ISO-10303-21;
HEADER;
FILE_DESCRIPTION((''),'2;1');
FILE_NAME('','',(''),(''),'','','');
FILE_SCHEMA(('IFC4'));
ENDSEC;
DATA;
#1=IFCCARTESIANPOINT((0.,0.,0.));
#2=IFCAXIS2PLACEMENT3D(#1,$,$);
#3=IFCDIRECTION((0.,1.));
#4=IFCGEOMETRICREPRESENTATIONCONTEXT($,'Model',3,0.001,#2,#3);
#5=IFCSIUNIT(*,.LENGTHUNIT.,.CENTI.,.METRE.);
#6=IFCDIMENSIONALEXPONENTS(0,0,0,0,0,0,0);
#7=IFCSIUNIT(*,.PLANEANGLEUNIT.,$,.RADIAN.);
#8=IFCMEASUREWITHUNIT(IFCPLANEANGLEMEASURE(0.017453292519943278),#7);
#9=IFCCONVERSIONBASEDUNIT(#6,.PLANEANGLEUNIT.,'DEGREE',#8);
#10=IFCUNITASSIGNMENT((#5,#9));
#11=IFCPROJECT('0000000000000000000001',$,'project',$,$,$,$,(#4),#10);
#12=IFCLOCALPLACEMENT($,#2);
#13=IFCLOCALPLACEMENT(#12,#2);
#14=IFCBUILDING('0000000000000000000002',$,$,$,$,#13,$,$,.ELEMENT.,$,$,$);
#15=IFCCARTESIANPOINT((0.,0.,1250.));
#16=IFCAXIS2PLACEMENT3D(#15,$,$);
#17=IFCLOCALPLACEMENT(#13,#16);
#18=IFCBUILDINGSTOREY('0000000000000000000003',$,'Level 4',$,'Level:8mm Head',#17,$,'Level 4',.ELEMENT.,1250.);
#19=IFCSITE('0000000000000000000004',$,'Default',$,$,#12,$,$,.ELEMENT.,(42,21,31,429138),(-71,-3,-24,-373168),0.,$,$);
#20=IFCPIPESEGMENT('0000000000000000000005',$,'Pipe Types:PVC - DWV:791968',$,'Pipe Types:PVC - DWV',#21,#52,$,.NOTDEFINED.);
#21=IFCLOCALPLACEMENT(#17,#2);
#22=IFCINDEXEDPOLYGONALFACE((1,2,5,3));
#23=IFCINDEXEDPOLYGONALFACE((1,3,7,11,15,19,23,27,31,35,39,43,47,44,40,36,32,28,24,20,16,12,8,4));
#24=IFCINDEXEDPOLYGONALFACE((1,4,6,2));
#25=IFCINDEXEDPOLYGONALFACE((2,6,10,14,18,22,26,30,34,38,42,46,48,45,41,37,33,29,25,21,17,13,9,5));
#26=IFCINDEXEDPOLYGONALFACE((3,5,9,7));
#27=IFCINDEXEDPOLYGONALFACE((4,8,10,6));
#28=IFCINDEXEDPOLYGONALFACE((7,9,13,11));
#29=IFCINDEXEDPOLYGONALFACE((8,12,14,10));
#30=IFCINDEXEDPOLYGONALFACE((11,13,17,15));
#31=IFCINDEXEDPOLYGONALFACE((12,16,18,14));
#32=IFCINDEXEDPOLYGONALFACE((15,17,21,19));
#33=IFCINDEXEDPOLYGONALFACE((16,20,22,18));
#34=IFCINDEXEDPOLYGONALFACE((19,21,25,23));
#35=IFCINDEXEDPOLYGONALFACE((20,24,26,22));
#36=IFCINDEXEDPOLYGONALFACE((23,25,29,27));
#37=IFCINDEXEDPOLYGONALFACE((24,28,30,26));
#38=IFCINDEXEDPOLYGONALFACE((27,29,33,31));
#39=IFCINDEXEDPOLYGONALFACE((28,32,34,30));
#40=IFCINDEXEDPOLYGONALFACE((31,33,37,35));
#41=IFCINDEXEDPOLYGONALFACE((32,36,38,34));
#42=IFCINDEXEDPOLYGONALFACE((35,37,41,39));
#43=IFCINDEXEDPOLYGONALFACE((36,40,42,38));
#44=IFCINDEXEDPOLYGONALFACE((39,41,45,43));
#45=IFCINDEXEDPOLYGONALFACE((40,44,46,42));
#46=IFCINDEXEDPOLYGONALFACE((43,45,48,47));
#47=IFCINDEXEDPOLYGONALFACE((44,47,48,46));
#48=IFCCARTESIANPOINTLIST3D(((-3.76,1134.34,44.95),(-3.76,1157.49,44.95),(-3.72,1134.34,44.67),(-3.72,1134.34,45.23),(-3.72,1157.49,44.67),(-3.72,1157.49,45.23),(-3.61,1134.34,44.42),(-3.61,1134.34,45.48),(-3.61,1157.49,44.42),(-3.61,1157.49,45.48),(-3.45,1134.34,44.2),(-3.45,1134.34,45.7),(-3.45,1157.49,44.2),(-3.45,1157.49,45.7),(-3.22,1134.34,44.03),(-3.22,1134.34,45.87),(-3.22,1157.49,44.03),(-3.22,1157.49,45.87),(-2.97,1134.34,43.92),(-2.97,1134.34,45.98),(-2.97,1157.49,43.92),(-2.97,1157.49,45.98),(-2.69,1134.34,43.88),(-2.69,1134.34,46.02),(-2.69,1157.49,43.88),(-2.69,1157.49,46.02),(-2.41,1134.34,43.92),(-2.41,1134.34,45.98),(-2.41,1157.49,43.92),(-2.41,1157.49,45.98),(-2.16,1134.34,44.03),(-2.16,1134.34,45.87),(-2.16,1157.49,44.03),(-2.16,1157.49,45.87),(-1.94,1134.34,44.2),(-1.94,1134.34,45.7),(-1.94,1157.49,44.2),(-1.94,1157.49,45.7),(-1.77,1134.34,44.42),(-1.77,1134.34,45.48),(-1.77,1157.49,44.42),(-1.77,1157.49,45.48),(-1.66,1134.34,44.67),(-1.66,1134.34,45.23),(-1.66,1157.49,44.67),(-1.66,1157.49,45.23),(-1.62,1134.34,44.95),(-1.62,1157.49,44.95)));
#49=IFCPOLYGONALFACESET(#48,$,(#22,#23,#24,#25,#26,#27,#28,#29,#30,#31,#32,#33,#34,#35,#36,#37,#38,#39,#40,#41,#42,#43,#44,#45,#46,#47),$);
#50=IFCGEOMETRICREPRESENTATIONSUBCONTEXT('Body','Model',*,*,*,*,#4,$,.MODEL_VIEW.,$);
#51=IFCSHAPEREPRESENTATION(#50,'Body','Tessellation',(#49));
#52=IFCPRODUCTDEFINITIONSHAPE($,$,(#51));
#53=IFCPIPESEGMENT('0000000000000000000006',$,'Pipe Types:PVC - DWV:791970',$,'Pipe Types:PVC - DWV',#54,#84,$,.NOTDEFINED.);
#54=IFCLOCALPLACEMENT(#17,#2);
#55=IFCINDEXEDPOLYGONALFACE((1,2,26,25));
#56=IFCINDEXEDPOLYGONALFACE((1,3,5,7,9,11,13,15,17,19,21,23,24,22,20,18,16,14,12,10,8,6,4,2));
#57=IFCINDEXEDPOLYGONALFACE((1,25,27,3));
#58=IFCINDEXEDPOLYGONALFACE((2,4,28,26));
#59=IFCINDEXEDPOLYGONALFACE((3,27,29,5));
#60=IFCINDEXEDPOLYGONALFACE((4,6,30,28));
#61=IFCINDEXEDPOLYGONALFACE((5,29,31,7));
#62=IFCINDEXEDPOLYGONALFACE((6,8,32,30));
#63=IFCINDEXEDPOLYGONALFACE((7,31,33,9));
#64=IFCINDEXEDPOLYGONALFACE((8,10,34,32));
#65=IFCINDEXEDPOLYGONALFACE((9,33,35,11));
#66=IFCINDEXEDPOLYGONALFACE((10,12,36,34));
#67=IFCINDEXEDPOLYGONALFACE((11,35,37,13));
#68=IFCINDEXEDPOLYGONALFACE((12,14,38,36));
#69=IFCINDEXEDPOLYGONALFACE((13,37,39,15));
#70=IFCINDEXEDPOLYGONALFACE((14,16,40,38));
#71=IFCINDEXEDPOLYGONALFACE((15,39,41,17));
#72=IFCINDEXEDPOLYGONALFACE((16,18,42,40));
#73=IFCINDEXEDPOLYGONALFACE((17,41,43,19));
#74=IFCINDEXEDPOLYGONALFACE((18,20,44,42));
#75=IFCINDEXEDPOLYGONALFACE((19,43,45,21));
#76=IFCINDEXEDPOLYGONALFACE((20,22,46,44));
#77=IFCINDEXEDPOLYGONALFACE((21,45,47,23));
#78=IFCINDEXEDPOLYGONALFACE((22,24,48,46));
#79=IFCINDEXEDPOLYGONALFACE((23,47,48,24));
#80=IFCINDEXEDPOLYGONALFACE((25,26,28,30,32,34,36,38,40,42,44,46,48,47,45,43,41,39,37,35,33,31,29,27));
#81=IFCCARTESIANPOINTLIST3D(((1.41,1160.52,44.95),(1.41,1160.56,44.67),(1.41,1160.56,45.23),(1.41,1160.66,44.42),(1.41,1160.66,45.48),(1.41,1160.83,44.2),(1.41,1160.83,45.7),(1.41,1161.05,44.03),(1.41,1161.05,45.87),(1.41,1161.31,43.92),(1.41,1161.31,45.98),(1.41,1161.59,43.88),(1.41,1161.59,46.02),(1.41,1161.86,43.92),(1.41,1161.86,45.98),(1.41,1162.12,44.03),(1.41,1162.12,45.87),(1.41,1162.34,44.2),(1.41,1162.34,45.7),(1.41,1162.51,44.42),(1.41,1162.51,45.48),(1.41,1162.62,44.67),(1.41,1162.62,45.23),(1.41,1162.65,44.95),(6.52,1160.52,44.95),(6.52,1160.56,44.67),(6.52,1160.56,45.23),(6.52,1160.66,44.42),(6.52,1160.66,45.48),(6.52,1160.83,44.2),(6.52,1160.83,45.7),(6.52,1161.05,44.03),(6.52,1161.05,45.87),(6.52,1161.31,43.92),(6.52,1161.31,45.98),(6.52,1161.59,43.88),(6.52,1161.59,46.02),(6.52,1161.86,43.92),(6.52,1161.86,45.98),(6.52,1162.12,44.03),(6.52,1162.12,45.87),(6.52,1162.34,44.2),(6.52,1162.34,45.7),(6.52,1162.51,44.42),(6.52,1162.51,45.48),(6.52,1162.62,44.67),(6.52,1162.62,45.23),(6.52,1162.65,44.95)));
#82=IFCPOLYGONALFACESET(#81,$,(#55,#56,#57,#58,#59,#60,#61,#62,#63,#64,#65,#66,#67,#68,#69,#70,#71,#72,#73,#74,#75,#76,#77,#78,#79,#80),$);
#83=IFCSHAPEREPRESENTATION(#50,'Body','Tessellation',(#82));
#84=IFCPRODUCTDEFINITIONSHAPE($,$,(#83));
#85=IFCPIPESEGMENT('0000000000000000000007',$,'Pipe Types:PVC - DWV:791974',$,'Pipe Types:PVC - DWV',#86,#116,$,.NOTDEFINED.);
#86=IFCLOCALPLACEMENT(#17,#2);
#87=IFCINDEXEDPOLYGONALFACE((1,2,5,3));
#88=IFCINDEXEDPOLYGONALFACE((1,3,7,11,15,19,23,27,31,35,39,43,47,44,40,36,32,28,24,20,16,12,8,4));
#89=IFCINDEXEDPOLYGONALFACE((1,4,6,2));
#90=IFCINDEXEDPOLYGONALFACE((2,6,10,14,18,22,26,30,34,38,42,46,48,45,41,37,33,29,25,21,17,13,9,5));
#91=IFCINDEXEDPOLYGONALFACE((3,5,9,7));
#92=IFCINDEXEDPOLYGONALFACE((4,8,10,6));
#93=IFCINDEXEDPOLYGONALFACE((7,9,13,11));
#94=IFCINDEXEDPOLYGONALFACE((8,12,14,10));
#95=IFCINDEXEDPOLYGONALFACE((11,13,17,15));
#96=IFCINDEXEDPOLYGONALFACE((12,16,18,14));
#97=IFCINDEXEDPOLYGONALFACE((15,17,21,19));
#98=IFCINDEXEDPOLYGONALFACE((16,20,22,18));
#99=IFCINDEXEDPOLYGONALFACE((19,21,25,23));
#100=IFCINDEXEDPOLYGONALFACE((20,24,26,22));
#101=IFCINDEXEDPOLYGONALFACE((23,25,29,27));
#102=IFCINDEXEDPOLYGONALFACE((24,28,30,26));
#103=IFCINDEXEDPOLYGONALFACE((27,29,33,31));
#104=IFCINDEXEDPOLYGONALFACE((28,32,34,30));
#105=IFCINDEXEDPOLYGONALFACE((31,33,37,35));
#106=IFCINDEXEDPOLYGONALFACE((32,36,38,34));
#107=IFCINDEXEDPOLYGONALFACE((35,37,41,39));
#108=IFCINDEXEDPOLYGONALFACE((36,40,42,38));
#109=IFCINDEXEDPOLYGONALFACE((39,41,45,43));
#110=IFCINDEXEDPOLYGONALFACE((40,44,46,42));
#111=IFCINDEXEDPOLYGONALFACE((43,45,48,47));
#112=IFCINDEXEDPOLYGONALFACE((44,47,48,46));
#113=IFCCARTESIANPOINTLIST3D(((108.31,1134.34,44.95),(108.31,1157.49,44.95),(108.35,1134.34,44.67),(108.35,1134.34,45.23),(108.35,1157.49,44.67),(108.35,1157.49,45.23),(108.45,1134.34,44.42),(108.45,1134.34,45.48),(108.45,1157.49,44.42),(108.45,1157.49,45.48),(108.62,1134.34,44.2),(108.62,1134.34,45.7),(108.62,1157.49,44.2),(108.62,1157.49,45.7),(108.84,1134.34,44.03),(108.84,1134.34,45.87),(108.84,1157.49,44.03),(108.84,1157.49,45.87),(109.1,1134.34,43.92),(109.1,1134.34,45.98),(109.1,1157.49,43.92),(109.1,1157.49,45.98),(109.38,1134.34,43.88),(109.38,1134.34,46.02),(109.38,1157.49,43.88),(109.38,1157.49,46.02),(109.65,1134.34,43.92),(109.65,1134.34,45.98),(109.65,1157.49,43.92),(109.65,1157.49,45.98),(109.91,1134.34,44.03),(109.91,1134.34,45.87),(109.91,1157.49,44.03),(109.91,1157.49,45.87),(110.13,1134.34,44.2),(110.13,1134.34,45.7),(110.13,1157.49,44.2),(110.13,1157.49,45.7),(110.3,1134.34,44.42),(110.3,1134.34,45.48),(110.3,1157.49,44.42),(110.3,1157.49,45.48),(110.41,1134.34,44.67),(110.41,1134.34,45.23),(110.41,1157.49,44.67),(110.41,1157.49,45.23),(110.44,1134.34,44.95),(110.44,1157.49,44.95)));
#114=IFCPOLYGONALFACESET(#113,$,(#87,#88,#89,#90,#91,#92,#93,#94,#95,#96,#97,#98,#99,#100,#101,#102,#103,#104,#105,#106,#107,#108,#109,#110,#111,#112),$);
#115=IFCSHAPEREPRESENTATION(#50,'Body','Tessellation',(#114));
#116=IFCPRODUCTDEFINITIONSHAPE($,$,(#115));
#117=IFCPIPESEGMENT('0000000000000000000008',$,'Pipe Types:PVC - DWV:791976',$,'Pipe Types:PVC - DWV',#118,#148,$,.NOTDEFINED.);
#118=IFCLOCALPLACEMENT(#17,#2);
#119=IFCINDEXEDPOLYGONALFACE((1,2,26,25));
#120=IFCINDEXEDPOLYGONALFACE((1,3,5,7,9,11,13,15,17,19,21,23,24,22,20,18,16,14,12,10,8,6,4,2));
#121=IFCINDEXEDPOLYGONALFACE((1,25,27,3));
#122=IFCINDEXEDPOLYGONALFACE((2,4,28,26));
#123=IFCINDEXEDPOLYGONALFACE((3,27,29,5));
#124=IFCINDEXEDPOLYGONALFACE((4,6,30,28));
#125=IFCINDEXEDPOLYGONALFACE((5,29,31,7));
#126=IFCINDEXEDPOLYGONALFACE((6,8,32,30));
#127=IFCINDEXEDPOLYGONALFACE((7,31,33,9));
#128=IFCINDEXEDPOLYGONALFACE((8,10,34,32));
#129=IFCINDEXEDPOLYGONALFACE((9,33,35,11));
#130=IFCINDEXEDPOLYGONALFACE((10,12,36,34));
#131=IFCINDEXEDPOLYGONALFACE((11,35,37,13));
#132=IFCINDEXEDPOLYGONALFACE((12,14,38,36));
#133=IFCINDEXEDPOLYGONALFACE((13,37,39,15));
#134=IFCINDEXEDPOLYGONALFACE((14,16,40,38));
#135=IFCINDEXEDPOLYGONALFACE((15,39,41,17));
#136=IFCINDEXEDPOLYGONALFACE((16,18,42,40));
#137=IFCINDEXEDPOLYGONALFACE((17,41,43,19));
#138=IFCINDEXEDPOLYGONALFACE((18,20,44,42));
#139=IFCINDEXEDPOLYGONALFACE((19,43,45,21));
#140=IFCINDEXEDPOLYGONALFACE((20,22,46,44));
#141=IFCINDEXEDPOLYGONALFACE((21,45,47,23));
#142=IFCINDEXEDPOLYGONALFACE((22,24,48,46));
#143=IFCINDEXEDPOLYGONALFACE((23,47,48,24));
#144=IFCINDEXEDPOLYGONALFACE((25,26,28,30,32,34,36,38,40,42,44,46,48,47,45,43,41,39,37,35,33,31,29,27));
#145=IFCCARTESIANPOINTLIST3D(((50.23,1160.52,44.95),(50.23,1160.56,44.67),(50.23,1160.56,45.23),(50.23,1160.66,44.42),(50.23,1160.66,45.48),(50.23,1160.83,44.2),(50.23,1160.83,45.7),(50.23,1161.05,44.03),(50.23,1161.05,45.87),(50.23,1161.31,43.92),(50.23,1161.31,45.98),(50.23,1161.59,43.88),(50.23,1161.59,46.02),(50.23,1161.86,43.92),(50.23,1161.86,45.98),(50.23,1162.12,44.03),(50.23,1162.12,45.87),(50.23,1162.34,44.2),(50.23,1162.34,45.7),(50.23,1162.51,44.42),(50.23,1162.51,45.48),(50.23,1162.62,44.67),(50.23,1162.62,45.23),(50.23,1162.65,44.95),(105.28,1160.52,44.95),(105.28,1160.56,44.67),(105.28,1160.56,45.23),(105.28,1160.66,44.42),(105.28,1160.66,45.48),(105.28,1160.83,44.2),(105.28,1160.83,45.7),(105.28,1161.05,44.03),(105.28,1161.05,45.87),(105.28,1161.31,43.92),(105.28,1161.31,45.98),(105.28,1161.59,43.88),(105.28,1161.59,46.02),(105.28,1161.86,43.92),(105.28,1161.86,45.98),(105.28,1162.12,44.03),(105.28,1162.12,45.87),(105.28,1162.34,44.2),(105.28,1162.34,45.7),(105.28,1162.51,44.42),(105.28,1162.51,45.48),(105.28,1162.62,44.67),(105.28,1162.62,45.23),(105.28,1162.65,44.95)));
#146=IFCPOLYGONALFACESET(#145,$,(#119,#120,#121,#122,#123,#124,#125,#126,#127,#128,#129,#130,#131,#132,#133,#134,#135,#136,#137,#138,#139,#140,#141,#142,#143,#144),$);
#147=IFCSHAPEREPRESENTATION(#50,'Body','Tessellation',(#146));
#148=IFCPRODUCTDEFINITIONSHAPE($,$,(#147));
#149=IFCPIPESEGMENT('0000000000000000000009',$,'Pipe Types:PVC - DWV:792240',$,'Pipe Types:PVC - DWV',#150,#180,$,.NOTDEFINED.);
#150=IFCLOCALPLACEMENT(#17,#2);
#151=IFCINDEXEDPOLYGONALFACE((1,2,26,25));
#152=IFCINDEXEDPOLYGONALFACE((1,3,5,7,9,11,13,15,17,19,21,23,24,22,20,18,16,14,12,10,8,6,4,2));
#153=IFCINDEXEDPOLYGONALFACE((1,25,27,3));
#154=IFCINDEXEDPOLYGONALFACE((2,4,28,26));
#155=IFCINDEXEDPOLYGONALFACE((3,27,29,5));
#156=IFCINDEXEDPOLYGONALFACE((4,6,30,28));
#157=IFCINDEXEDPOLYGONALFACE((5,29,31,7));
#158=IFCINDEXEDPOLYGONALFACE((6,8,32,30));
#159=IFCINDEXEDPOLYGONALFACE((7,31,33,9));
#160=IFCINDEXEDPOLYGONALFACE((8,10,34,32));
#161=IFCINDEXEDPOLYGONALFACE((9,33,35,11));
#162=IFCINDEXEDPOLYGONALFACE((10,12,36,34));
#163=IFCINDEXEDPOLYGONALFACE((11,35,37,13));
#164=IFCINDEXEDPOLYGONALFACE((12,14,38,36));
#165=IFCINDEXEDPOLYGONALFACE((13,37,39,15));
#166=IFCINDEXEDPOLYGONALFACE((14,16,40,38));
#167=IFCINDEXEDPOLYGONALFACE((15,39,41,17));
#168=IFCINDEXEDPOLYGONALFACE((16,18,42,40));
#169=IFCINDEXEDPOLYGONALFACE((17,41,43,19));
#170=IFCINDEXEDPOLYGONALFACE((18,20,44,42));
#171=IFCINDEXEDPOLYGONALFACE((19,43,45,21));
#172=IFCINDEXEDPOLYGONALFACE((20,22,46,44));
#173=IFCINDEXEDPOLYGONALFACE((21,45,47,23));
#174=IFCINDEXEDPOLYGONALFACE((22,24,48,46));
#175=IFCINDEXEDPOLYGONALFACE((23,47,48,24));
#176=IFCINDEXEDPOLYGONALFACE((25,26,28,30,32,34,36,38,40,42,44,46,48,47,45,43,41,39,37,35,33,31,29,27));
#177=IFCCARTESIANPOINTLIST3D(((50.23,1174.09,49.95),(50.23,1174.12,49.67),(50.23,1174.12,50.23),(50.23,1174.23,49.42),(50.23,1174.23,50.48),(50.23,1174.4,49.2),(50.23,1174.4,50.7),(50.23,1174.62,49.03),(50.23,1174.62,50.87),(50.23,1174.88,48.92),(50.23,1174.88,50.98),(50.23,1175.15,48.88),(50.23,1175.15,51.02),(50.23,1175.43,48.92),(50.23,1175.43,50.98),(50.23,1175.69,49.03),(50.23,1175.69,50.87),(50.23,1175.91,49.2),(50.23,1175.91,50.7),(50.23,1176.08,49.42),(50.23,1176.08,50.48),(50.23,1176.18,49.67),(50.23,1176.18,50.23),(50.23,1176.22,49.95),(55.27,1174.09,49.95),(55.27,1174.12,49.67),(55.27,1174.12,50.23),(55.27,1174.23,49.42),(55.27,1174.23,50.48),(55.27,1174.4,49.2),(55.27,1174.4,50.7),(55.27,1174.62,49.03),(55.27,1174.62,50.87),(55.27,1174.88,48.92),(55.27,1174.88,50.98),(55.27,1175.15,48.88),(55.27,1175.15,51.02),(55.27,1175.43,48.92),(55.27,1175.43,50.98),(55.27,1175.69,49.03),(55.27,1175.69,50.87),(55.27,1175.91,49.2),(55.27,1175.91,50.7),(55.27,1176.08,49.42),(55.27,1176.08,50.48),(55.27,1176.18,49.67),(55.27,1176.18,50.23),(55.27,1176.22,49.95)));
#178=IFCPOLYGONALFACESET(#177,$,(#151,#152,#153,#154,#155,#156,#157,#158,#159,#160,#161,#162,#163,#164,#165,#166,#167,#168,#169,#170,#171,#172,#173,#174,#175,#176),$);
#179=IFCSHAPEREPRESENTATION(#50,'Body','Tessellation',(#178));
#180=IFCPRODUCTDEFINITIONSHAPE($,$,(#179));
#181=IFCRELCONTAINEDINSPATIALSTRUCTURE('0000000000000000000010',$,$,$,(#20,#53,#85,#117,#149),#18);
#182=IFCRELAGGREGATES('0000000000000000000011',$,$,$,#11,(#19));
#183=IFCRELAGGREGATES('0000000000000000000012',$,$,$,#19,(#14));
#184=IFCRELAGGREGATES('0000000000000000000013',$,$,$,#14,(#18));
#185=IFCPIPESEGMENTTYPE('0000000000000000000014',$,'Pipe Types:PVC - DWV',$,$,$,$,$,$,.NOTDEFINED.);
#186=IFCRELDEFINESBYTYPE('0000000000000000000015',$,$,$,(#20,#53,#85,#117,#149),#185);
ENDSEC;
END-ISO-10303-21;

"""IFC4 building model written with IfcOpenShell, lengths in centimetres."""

from ifc_helpers import new_model, entity, si_unit, converted_unit, direction, frame, origin, place, context, subcontext, project, spatial, arc, indexed_curve, outline, extrude, type_object, element, save


model = new_model("IFC4")

# Units and contexts
model_context = context("Model", 3, precision=0.001, world=origin(), true_north=direction((0.0, 1.0)))
body_context = subcontext(model_context, "Body", "Model", "MODEL_VIEW")
ifc_project = project(units=[si_unit("LENGTHUNIT", "METRE", prefix="CENTI"), converted_unit("PLANEANGLEUNIT", "DEGREE", entity("IfcPlaneAngleMeasure", 0.017453292519943278), si_unit("PLANEANGLEUNIT", "RADIAN"), dimensions=[0, 0, 0, 0, 0, 0, 0])], contexts=[model_context])

# Site, building, storey
site_placement = place(None, origin())
site = spatial("IfcSite", under=ifc_project, at=site_placement, Name="Default", CompositionType="ELEMENT", RefLatitude=(42, 21, 31, 429138), RefLongitude=(-71, -3, -24, -373168), RefElevation=0.0)
building_placement = place(site_placement, origin())
building = spatial("IfcBuilding", under=site, at=building_placement, CompositionType="ELEMENT")
storey_placement = place(building_placement, frame((0.0, 0.0, 1250.0)))
storey = spatial("IfcBuildingStorey", under=building, at=storey_placement, Name="Level 4", ObjectType="Level:8mm Head", LongName="Level 4", CompositionType="ELEMENT", Elevation=1250.0)

# Pipe segments
pipe_segment_type = type_object("IfcPipeSegmentType", Name="Pipe Types:PVC - DWV", PredefinedType="NOTDEFINED")
pipe_segment_1_placement = place(storey_placement, origin())
element("IfcPipeSegment", 1, at=pipe_segment_1_placement, inside=storey, type_object=pipe_segment_type, Name="Pipe Types:PVC - DWV:791968", ObjectType="Pipe Types:PVC - DWV", PredefinedType="NOTDEFINED", context=body_context, shape_type="SweptSolid", body=[
    extrude(outline(indexed_curve([(1.07, 0.0), (0.75, 0.75), (0.0, 1.07), (-0.75, 0.75), (-1.07, 0.0), (-0.75, -0.75), (0.0, -1.07), (0.75, -0.75)], segments=[arc(1, 2, 3), arc(3, 4, 5), arc(5, 6, 7), arc(7, 8, 1)], self_intersect=False)), frame((-2.69, 1134.34, 44.95), z_axis=(0.0, 1.0, 0.0), x_axis=(1.0, 0.0, 0.0)), (0.0, 0.0, 1.0), 23.14),
])
pipe_segment_2_placement = place(storey_placement, origin())
element("IfcPipeSegment", 2, at=pipe_segment_2_placement, inside=storey, type_object=pipe_segment_type, Name="Pipe Types:PVC - DWV:791970", ObjectType="Pipe Types:PVC - DWV", PredefinedType="NOTDEFINED", context=body_context, shape_type="SweptSolid", body=[
    extrude(outline(indexed_curve([(1.07, 0.0), (0.75, 0.75), (0.0, 1.07), (-0.75, 0.75), (-1.07, 0.0), (-0.75, -0.75), (0.0, -1.07), (0.75, -0.75)], segments=[arc(1, 2, 3), arc(3, 4, 5), arc(5, 6, 7), arc(7, 8, 1)], self_intersect=False)), frame((1.41, 1161.59, 44.95), z_axis=(1.0, 0.0, 0.0), x_axis=(0.0, -1.0, 0.0)), (0.0, 0.0, 1.0), 5.11),
])
pipe_segment_3_placement = place(storey_placement, origin())
element("IfcPipeSegment", 3, at=pipe_segment_3_placement, inside=storey, type_object=pipe_segment_type, Name="Pipe Types:PVC - DWV:791974", ObjectType="Pipe Types:PVC - DWV", PredefinedType="NOTDEFINED", context=body_context, shape_type="SweptSolid", body=[
    extrude(outline(indexed_curve([(1.07, 0.0), (0.75, 0.75), (0.0, 1.07), (-0.75, 0.75), (-1.07, 0.0), (-0.75, -0.75), (0.0, -1.07), (0.75, -0.75)], segments=[arc(1, 2, 3), arc(3, 4, 5), arc(5, 6, 7), arc(7, 8, 1)], self_intersect=False)), frame((109.38, 1134.34, 44.95), z_axis=(0.0, 1.0, 0.0), x_axis=(-1.0, 0.0, 0.0)), (0.0, 0.0, 1.0), 23.14),
])
pipe_segment_4_placement = place(storey_placement, origin())
element("IfcPipeSegment", 4, at=pipe_segment_4_placement, inside=storey, type_object=pipe_segment_type, Name="Pipe Types:PVC - DWV:791976", ObjectType="Pipe Types:PVC - DWV", PredefinedType="NOTDEFINED", context=body_context, shape_type="SweptSolid", body=[
    extrude(outline(indexed_curve([(1.07, 0.0), (0.75, 0.75), (0.0, 1.07), (-0.75, 0.75), (-1.07, 0.0), (-0.75, -0.75), (0.0, -1.07), (0.75, -0.75)], segments=[arc(1, 2, 3), arc(3, 4, 5), arc(5, 6, 7), arc(7, 8, 1)], self_intersect=False)), frame((50.23, 1161.59, 44.95), z_axis=(1.0, 0.0, 0.0), x_axis=(0.0, 1.0, 0.0)), (0.0, 0.0, 1.0), 55.04),
])
pipe_segment_5_placement = place(storey_placement, origin())
element("IfcPipeSegment", 5, at=pipe_segment_5_placement, inside=storey, type_object=pipe_segment_type, Name="Pipe Types:PVC - DWV:792240", ObjectType="Pipe Types:PVC - DWV", PredefinedType="NOTDEFINED", context=body_context, shape_type="SweptSolid", body=[
    extrude(outline(indexed_curve([(1.07, 0.0), (0.75, 0.75), (0.0, 1.07), (-0.75, 0.75), (-1.07, 0.0), (-0.75, -0.75), (0.0, -1.07), (0.75, -0.75)], segments=[arc(1, 2, 3), arc(3, 4, 5), arc(5, 6, 7), arc(7, 8, 1)], self_intersect=False)), frame((50.23, 1175.15, 49.95), z_axis=(1.0, 0.0, 0.0), x_axis=(0.0, 1.0, 0.0)), (0.0, 0.0, 1.0), 5.04),
])

save(model, "model.ifc")
